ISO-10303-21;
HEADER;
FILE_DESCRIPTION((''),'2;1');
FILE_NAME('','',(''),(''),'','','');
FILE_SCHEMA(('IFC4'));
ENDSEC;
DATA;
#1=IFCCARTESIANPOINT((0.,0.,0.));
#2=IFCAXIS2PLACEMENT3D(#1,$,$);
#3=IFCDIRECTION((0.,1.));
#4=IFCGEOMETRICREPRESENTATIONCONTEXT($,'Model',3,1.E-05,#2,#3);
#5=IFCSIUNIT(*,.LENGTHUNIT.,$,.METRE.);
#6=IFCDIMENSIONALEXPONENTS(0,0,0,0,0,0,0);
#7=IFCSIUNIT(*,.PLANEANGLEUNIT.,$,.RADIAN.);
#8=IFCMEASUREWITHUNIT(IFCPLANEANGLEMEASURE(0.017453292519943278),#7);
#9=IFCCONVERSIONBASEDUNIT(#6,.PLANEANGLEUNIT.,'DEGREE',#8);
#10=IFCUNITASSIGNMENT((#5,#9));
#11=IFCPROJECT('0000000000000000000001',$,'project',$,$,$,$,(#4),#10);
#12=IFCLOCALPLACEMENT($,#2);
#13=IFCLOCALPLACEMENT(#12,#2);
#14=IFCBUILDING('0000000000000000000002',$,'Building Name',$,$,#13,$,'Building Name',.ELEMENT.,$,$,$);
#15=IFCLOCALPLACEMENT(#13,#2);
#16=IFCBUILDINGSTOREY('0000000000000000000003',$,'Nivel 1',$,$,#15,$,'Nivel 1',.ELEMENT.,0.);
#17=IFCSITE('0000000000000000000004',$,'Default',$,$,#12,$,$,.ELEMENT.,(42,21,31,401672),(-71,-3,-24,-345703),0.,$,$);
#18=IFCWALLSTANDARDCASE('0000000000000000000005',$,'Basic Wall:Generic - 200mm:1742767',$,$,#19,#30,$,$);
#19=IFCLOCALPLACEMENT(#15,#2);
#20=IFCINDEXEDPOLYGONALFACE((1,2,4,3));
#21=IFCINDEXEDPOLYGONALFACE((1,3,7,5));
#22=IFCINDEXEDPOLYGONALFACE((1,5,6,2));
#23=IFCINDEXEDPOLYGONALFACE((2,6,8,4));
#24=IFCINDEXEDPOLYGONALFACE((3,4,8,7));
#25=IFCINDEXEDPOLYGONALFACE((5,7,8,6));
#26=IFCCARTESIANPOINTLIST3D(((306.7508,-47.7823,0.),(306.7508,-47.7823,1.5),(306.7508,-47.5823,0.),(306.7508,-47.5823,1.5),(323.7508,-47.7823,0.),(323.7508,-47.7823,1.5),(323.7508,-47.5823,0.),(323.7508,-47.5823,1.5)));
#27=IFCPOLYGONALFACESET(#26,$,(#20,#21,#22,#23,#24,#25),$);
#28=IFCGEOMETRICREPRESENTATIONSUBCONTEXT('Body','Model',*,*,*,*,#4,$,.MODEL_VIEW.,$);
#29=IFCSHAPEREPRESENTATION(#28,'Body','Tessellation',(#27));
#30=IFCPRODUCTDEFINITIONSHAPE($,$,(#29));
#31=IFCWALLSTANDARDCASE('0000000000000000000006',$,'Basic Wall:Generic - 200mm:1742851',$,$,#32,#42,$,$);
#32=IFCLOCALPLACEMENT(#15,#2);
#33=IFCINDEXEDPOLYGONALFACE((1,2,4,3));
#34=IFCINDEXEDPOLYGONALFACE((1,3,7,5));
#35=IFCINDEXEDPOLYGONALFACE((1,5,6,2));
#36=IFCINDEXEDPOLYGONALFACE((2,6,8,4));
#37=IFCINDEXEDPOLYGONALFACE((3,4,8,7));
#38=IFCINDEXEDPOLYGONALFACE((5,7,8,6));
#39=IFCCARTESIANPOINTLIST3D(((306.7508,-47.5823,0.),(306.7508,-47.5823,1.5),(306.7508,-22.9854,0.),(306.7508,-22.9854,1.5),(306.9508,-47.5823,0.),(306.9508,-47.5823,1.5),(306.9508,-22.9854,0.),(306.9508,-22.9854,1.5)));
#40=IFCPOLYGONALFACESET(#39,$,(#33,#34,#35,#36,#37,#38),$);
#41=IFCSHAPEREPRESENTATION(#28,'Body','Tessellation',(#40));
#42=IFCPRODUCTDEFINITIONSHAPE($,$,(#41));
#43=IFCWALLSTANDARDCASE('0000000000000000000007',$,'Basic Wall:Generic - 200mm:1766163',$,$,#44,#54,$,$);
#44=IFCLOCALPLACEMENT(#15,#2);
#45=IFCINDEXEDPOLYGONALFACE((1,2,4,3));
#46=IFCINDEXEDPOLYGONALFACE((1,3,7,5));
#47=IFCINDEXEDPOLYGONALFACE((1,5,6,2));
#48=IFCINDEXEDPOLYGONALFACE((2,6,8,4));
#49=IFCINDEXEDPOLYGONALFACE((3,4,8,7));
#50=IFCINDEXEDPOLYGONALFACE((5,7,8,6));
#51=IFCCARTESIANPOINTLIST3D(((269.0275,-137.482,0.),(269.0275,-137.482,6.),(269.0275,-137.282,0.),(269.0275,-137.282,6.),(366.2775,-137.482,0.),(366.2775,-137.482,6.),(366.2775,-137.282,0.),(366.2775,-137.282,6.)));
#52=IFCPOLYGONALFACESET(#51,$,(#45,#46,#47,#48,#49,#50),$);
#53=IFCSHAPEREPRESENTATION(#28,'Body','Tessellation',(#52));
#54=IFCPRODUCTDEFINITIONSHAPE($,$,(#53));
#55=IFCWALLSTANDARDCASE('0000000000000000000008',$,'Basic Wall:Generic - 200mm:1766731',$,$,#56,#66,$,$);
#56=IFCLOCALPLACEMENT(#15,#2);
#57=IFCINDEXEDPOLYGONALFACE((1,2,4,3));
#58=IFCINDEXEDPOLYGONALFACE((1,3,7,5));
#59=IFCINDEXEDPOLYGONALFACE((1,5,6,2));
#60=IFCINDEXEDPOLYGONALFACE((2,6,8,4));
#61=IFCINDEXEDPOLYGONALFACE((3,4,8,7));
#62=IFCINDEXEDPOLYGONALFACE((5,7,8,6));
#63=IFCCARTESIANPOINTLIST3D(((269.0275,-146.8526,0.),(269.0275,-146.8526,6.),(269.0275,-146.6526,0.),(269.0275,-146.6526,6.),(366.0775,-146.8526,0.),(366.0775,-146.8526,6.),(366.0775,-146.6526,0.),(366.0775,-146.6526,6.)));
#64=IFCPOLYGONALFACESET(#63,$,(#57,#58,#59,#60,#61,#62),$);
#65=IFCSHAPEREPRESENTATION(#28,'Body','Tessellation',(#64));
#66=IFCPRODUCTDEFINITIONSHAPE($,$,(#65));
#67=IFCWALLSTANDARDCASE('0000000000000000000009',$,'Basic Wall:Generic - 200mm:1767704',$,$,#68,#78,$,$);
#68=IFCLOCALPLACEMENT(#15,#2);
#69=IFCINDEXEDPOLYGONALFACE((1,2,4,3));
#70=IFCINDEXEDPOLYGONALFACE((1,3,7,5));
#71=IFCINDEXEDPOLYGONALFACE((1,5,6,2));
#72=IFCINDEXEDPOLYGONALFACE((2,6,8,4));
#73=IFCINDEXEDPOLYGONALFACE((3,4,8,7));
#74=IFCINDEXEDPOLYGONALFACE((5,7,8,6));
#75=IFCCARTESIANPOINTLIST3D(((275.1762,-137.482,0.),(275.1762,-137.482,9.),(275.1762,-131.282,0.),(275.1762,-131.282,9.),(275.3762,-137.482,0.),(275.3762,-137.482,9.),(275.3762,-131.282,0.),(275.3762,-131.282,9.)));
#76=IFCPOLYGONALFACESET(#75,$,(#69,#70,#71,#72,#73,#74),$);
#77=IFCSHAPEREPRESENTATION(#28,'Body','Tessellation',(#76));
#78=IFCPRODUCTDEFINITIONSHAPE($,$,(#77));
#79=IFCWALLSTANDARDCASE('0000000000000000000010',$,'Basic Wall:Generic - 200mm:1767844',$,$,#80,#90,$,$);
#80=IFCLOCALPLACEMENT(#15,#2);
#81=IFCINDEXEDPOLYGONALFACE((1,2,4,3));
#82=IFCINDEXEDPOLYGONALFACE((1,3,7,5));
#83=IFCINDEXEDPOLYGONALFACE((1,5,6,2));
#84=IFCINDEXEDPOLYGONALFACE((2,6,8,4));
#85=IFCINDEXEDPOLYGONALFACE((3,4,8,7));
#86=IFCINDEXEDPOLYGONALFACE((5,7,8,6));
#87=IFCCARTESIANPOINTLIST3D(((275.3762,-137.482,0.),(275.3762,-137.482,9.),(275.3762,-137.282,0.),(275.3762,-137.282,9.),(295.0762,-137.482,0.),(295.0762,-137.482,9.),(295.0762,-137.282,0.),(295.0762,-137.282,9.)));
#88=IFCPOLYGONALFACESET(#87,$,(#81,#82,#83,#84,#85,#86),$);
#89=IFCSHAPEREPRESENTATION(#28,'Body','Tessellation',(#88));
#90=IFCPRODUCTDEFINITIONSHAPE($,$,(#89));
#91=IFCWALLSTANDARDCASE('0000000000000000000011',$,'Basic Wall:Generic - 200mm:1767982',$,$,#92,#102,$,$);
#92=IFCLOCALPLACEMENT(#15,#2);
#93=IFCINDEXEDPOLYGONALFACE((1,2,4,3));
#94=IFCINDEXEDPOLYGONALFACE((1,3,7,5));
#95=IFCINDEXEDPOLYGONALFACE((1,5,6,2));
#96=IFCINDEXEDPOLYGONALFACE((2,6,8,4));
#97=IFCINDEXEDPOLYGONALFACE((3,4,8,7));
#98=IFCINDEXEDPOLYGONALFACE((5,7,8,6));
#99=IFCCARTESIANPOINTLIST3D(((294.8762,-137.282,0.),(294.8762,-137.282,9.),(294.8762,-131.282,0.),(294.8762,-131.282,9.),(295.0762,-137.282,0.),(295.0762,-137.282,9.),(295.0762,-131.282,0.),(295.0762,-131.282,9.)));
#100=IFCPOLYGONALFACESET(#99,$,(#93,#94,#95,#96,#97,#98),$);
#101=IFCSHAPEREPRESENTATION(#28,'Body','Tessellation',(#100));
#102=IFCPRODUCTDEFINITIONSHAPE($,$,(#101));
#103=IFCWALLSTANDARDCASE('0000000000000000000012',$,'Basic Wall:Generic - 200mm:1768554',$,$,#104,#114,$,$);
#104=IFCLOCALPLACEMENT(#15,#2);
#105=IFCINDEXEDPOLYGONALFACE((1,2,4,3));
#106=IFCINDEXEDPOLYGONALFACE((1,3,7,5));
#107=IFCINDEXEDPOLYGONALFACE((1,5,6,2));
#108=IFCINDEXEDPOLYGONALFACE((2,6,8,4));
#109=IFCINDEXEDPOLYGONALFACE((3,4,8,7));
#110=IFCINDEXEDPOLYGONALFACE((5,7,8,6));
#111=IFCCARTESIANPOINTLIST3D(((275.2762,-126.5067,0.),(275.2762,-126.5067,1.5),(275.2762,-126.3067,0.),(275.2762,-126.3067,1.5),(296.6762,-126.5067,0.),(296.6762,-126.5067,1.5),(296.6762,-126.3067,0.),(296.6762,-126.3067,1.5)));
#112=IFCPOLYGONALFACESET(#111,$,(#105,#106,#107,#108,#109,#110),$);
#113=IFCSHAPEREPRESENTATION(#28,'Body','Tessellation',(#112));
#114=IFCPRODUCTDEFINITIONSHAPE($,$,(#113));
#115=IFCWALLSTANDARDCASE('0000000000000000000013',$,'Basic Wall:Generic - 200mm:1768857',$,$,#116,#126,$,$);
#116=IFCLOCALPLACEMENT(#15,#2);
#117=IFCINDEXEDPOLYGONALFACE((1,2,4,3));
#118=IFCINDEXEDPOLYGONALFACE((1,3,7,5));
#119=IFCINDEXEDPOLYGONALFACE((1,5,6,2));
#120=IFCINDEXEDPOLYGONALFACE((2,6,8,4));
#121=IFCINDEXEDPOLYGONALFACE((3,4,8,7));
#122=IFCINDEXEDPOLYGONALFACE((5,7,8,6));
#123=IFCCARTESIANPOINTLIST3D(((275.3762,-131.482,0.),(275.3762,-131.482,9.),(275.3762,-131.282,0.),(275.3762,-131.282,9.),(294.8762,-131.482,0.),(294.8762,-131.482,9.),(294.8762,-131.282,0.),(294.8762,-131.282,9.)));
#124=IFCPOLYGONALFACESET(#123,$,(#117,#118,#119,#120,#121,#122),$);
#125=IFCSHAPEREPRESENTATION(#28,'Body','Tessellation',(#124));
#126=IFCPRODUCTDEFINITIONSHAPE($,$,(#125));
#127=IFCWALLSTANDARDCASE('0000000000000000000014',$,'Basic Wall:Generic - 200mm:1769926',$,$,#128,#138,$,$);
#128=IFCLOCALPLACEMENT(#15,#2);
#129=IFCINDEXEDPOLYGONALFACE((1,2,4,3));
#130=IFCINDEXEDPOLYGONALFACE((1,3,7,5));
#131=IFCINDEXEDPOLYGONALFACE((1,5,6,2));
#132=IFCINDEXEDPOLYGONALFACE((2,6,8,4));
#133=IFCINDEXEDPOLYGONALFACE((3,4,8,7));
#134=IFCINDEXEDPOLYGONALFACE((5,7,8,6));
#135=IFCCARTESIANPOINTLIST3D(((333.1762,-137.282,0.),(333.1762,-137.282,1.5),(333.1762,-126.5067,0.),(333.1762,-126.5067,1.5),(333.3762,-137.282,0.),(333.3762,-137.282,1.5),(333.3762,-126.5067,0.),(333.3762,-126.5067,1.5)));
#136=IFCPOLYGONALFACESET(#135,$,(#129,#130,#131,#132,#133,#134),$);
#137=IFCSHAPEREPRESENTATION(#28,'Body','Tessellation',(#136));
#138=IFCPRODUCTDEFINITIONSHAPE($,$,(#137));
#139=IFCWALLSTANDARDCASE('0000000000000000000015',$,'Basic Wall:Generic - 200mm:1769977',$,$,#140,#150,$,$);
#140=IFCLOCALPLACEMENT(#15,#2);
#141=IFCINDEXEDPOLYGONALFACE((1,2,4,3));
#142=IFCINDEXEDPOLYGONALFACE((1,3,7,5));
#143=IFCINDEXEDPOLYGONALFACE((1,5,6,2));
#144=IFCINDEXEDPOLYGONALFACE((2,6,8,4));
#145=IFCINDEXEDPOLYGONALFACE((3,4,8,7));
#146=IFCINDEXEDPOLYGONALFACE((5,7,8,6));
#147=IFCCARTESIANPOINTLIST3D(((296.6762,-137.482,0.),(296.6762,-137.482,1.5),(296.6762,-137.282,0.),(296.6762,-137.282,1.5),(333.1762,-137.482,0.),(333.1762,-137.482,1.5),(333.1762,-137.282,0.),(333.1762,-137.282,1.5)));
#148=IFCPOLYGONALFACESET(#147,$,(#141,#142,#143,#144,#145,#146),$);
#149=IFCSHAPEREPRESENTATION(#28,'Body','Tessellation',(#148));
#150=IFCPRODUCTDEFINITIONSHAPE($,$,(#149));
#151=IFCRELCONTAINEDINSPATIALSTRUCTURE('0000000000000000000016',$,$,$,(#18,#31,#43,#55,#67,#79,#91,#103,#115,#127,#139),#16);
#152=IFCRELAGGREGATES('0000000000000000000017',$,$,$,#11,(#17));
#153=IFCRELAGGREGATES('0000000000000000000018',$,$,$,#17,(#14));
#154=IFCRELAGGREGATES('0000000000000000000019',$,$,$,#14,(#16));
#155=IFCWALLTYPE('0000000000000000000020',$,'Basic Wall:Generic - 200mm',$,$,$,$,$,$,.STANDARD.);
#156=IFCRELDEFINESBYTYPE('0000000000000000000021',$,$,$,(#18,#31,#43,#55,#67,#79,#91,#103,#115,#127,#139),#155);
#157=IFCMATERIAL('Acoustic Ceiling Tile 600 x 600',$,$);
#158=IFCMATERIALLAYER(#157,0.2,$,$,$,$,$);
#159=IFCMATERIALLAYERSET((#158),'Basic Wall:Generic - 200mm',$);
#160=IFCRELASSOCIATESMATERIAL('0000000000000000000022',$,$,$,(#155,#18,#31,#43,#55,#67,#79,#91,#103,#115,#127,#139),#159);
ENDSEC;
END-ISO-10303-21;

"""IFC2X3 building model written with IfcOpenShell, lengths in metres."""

from ifc_helpers import new_model, entity, si_unit, converted_unit, direction, frame, frame_2d, origin, place, context, subcontext, project, spatial, rectangle, extrude, material, layer, layer_set, layer_usage, type_object, element, save


model = new_model("IFC2X3")

# Units and contexts
model_context = context("Model", 3, precision=1e-05, world=origin(), true_north=direction((0.0, 1.0)))
body_context = subcontext(model_context, "Body", "Model", "MODEL_VIEW")
ifc_project = project(units=[si_unit("LENGTHUNIT", "METRE"), converted_unit("PLANEANGLEUNIT", "DEGREE", entity("IfcPlaneAngleMeasure", 0.017453292519943278), si_unit("PLANEANGLEUNIT", "RADIAN"), dimensions=[0, 0, 0, 0, 0, 0, 0])], contexts=[model_context])

# Site, building, storey
site_placement = place(None, origin())
site = spatial("IfcSite", under=ifc_project, at=site_placement, Name="Default", CompositionType="ELEMENT", RefLatitude=(42, 21, 31, 401672), RefLongitude=(-71, -3, -24, -345703), RefElevation=0.0)
building_placement = place(site_placement, origin())
building = spatial("IfcBuilding", under=site, at=building_placement, Name="Building Name", LongName="Building Name", CompositionType="ELEMENT")
storey_placement = place(building_placement, origin())
storey = spatial("IfcBuildingStorey", under=building, at=storey_placement, Name="Nivel 1", LongName="Nivel 1", CompositionType="ELEMENT", Elevation=0.0)

# Walls
ifc_material_1 = material(Name="Acoustic Ceiling Tile 600 x 600")
ifc_layer = layer(ifc_material_1, 0.2)
ifc_layer_set = layer_set([ifc_layer], Name="Basic Wall:Generic - 200mm")
wall_type_1 = type_object("IfcWallType", Name="Basic Wall:Generic - 200mm", PredefinedType="STANDARD", material=ifc_layer_set)
ifc_layer_usage_1 = layer_usage(ifc_layer_set, "AXIS2", "NEGATIVE", 0.1)
wall_1_placement = place(storey_placement, frame((323.7508, -47.6823, 0.0), z_axis=(0.0, 0.0, 1.0), x_axis=(-1.0, 0.0, 0.0)))
element("IfcWallStandardCase", 1, at=wall_1_placement, inside=storey, type_object=wall_type_1, material=ifc_layer_usage_1, Name="Basic Wall:Generic - 200mm:1742767", context=body_context, shape_type="SweptSolid", body=[
    extrude(rectangle(XDim=17.0, YDim=0.2, at=frame_2d((8.5, 0.0), x_axis=(-1.0, 0.0))), origin(), (0.0, 0.0, 1.0), 1.5),
])
ifc_layer_usage_2 = layer_usage(ifc_layer_set, "AXIS2", "NEGATIVE", 0.1)
wall_2_placement = place(storey_placement, frame((306.8508, -47.5823, 0.0), z_axis=(0.0, 0.0, 1.0), x_axis=(0.0, 1.0, 0.0)))
element("IfcWallStandardCase", 2, at=wall_2_placement, inside=storey, type_object=wall_type_1, material=ifc_layer_usage_2, Name="Basic Wall:Generic - 200mm:1742851", context=body_context, shape_type="SweptSolid", body=[
    extrude(rectangle(XDim=24.5969, YDim=0.2, at=frame_2d((12.2985, 0.0), x_axis=(-1.0, 0.0))), origin(), (0.0, 0.0, 1.0), 1.5),
])
ifc_layer_usage_3 = layer_usage(ifc_layer_set, "AXIS2", "NEGATIVE", 0.1)
wall_3_placement = place(storey_placement, frame((269.0275, -137.382, 0.0)))
element("IfcWallStandardCase", 3, at=wall_3_placement, inside=storey, type_object=wall_type_1, material=ifc_layer_usage_3, Name="Basic Wall:Generic - 200mm:1766163", context=body_context, shape_type="SweptSolid", body=[
    extrude(rectangle(XDim=97.25, YDim=0.2, at=frame_2d((48.625, 0.0), x_axis=(-1.0, 0.0))), origin(), (0.0, 0.0, 1.0), 6.0),
])
ifc_layer_usage_4 = layer_usage(ifc_layer_set, "AXIS2", "NEGATIVE", 0.1)
wall_4_placement = place(storey_placement, frame((269.0275, -146.7526, 0.0)))
element("IfcWallStandardCase", 4, at=wall_4_placement, inside=storey, type_object=wall_type_1, material=ifc_layer_usage_4, Name="Basic Wall:Generic - 200mm:1766731", context=body_context, shape_type="SweptSolid", body=[
    extrude(rectangle(XDim=97.05, YDim=0.2, at=frame_2d((48.525, 0.0), x_axis=(-1.0, 0.0))), origin(), (0.0, 0.0, 1.0), 6.0),
])
ifc_layer_usage_5 = layer_usage(ifc_layer_set, "AXIS2", "NEGATIVE", 0.1)
wall_5_placement = place(storey_placement, frame((275.2762, -131.282, 0.0), z_axis=(0.0, 0.0, 1.0), x_axis=(0.0, -1.0, 0.0)))
element("IfcWallStandardCase", 5, at=wall_5_placement, inside=storey, type_object=wall_type_1, material=ifc_layer_usage_5, Name="Basic Wall:Generic - 200mm:1767704", context=body_context, shape_type="SweptSolid", body=[
    extrude(rectangle(XDim=6.2, YDim=0.2, at=frame_2d((3.1, 0.0), x_axis=(-1.0, 0.0))), origin(), (0.0, 0.0, 1.0), 9.0),
])
ifc_layer_usage_6 = layer_usage(ifc_layer_set, "AXIS2", "NEGATIVE", 0.1)
wall_6_placement = place(storey_placement, frame((275.3762, -137.382, 0.0)))
element("IfcWallStandardCase", 6, at=wall_6_placement, inside=storey, type_object=wall_type_1, material=ifc_layer_usage_6, Name="Basic Wall:Generic - 200mm:1767844", context=body_context, shape_type="SweptSolid", body=[
    extrude(rectangle(XDim=19.7, YDim=0.2, at=frame_2d((9.85, 0.0), x_axis=(-1.0, 0.0))), origin(), (0.0, 0.0, 1.0), 9.0),
])
ifc_layer_usage_7 = layer_usage(ifc_layer_set, "AXIS2", "NEGATIVE", 0.1)
wall_7_placement = place(storey_placement, frame((294.9762, -137.282, 0.0), z_axis=(0.0, 0.0, 1.0), x_axis=(0.0, 1.0, 0.0)))
element("IfcWallStandardCase", 7, at=wall_7_placement, inside=storey, type_object=wall_type_1, material=ifc_layer_usage_7, Name="Basic Wall:Generic - 200mm:1767982", context=body_context, shape_type="SweptSolid", body=[
    extrude(rectangle(XDim=6.0, YDim=0.2, at=frame_2d((3.0, 0.0), x_axis=(-1.0, 0.0))), origin(), (0.0, 0.0, 1.0), 9.0),
])
ifc_layer_usage_8 = layer_usage(ifc_layer_set, "AXIS2", "NEGATIVE", 0.1)
wall_8_placement = place(storey_placement, frame((275.2762, -126.4067, 0.0)))
element("IfcWallStandardCase", 8, at=wall_8_placement, inside=storey, type_object=wall_type_1, material=ifc_layer_usage_8, Name="Basic Wall:Generic - 200mm:1768554", context=body_context, shape_type="SweptSolid", body=[
    extrude(rectangle(XDim=21.4, YDim=0.2, at=frame_2d((10.7, 0.0), x_axis=(-1.0, 0.0))), origin(), (0.0, 0.0, 1.0), 1.5),
])
ifc_layer_usage_9 = layer_usage(ifc_layer_set, "AXIS2", "NEGATIVE", 0.1)
wall_9_placement = place(storey_placement, frame((275.3762, -131.382, 0.0)))
element("IfcWallStandardCase", 9, at=wall_9_placement, inside=storey, type_object=wall_type_1, material=ifc_layer_usage_9, Name="Basic Wall:Generic - 200mm:1768857", context=body_context, shape_type="SweptSolid", body=[
    extrude(rectangle(XDim=19.5, YDim=0.2, at=frame_2d((9.75, 0.0), x_axis=(-1.0, 0.0))), origin(), (0.0, 0.0, 1.0), 9.0),
])
ifc_layer_usage_10 = layer_usage(ifc_layer_set, "AXIS2", "NEGATIVE", 0.1)
wall_10_placement = place(storey_placement, frame((333.2762, -126.5067, 0.0), z_axis=(0.0, 0.0, 1.0), x_axis=(0.0, -1.0, 0.0)))
element("IfcWallStandardCase", 10, at=wall_10_placement, inside=storey, type_object=wall_type_1, material=ifc_layer_usage_10, Name="Basic Wall:Generic - 200mm:1769926", context=body_context, shape_type="SweptSolid", body=[
    extrude(rectangle(XDim=10.7752, YDim=0.2, at=frame_2d((5.3876, 0.0), x_axis=(-1.0, 0.0))), origin(), (0.0, 0.0, 1.0), 1.5),
])
ifc_layer_usage_11 = layer_usage(ifc_layer_set, "AXIS2", "NEGATIVE", 0.1)
wall_11_placement = place(storey_placement, frame((296.6762, -137.382, 0.0)))
element("IfcWallStandardCase", 11, at=wall_11_placement, inside=storey, type_object=wall_type_1, material=ifc_layer_usage_11, Name="Basic Wall:Generic - 200mm:1769977", context=body_context, shape_type="SweptSolid", body=[
    extrude(rectangle(XDim=36.5, YDim=0.2, at=frame_2d((18.25, 0.0), x_axis=(-1.0, 0.0))), origin(), (0.0, 0.0, 1.0), 1.5),
])

save(model, "model.ifc")
